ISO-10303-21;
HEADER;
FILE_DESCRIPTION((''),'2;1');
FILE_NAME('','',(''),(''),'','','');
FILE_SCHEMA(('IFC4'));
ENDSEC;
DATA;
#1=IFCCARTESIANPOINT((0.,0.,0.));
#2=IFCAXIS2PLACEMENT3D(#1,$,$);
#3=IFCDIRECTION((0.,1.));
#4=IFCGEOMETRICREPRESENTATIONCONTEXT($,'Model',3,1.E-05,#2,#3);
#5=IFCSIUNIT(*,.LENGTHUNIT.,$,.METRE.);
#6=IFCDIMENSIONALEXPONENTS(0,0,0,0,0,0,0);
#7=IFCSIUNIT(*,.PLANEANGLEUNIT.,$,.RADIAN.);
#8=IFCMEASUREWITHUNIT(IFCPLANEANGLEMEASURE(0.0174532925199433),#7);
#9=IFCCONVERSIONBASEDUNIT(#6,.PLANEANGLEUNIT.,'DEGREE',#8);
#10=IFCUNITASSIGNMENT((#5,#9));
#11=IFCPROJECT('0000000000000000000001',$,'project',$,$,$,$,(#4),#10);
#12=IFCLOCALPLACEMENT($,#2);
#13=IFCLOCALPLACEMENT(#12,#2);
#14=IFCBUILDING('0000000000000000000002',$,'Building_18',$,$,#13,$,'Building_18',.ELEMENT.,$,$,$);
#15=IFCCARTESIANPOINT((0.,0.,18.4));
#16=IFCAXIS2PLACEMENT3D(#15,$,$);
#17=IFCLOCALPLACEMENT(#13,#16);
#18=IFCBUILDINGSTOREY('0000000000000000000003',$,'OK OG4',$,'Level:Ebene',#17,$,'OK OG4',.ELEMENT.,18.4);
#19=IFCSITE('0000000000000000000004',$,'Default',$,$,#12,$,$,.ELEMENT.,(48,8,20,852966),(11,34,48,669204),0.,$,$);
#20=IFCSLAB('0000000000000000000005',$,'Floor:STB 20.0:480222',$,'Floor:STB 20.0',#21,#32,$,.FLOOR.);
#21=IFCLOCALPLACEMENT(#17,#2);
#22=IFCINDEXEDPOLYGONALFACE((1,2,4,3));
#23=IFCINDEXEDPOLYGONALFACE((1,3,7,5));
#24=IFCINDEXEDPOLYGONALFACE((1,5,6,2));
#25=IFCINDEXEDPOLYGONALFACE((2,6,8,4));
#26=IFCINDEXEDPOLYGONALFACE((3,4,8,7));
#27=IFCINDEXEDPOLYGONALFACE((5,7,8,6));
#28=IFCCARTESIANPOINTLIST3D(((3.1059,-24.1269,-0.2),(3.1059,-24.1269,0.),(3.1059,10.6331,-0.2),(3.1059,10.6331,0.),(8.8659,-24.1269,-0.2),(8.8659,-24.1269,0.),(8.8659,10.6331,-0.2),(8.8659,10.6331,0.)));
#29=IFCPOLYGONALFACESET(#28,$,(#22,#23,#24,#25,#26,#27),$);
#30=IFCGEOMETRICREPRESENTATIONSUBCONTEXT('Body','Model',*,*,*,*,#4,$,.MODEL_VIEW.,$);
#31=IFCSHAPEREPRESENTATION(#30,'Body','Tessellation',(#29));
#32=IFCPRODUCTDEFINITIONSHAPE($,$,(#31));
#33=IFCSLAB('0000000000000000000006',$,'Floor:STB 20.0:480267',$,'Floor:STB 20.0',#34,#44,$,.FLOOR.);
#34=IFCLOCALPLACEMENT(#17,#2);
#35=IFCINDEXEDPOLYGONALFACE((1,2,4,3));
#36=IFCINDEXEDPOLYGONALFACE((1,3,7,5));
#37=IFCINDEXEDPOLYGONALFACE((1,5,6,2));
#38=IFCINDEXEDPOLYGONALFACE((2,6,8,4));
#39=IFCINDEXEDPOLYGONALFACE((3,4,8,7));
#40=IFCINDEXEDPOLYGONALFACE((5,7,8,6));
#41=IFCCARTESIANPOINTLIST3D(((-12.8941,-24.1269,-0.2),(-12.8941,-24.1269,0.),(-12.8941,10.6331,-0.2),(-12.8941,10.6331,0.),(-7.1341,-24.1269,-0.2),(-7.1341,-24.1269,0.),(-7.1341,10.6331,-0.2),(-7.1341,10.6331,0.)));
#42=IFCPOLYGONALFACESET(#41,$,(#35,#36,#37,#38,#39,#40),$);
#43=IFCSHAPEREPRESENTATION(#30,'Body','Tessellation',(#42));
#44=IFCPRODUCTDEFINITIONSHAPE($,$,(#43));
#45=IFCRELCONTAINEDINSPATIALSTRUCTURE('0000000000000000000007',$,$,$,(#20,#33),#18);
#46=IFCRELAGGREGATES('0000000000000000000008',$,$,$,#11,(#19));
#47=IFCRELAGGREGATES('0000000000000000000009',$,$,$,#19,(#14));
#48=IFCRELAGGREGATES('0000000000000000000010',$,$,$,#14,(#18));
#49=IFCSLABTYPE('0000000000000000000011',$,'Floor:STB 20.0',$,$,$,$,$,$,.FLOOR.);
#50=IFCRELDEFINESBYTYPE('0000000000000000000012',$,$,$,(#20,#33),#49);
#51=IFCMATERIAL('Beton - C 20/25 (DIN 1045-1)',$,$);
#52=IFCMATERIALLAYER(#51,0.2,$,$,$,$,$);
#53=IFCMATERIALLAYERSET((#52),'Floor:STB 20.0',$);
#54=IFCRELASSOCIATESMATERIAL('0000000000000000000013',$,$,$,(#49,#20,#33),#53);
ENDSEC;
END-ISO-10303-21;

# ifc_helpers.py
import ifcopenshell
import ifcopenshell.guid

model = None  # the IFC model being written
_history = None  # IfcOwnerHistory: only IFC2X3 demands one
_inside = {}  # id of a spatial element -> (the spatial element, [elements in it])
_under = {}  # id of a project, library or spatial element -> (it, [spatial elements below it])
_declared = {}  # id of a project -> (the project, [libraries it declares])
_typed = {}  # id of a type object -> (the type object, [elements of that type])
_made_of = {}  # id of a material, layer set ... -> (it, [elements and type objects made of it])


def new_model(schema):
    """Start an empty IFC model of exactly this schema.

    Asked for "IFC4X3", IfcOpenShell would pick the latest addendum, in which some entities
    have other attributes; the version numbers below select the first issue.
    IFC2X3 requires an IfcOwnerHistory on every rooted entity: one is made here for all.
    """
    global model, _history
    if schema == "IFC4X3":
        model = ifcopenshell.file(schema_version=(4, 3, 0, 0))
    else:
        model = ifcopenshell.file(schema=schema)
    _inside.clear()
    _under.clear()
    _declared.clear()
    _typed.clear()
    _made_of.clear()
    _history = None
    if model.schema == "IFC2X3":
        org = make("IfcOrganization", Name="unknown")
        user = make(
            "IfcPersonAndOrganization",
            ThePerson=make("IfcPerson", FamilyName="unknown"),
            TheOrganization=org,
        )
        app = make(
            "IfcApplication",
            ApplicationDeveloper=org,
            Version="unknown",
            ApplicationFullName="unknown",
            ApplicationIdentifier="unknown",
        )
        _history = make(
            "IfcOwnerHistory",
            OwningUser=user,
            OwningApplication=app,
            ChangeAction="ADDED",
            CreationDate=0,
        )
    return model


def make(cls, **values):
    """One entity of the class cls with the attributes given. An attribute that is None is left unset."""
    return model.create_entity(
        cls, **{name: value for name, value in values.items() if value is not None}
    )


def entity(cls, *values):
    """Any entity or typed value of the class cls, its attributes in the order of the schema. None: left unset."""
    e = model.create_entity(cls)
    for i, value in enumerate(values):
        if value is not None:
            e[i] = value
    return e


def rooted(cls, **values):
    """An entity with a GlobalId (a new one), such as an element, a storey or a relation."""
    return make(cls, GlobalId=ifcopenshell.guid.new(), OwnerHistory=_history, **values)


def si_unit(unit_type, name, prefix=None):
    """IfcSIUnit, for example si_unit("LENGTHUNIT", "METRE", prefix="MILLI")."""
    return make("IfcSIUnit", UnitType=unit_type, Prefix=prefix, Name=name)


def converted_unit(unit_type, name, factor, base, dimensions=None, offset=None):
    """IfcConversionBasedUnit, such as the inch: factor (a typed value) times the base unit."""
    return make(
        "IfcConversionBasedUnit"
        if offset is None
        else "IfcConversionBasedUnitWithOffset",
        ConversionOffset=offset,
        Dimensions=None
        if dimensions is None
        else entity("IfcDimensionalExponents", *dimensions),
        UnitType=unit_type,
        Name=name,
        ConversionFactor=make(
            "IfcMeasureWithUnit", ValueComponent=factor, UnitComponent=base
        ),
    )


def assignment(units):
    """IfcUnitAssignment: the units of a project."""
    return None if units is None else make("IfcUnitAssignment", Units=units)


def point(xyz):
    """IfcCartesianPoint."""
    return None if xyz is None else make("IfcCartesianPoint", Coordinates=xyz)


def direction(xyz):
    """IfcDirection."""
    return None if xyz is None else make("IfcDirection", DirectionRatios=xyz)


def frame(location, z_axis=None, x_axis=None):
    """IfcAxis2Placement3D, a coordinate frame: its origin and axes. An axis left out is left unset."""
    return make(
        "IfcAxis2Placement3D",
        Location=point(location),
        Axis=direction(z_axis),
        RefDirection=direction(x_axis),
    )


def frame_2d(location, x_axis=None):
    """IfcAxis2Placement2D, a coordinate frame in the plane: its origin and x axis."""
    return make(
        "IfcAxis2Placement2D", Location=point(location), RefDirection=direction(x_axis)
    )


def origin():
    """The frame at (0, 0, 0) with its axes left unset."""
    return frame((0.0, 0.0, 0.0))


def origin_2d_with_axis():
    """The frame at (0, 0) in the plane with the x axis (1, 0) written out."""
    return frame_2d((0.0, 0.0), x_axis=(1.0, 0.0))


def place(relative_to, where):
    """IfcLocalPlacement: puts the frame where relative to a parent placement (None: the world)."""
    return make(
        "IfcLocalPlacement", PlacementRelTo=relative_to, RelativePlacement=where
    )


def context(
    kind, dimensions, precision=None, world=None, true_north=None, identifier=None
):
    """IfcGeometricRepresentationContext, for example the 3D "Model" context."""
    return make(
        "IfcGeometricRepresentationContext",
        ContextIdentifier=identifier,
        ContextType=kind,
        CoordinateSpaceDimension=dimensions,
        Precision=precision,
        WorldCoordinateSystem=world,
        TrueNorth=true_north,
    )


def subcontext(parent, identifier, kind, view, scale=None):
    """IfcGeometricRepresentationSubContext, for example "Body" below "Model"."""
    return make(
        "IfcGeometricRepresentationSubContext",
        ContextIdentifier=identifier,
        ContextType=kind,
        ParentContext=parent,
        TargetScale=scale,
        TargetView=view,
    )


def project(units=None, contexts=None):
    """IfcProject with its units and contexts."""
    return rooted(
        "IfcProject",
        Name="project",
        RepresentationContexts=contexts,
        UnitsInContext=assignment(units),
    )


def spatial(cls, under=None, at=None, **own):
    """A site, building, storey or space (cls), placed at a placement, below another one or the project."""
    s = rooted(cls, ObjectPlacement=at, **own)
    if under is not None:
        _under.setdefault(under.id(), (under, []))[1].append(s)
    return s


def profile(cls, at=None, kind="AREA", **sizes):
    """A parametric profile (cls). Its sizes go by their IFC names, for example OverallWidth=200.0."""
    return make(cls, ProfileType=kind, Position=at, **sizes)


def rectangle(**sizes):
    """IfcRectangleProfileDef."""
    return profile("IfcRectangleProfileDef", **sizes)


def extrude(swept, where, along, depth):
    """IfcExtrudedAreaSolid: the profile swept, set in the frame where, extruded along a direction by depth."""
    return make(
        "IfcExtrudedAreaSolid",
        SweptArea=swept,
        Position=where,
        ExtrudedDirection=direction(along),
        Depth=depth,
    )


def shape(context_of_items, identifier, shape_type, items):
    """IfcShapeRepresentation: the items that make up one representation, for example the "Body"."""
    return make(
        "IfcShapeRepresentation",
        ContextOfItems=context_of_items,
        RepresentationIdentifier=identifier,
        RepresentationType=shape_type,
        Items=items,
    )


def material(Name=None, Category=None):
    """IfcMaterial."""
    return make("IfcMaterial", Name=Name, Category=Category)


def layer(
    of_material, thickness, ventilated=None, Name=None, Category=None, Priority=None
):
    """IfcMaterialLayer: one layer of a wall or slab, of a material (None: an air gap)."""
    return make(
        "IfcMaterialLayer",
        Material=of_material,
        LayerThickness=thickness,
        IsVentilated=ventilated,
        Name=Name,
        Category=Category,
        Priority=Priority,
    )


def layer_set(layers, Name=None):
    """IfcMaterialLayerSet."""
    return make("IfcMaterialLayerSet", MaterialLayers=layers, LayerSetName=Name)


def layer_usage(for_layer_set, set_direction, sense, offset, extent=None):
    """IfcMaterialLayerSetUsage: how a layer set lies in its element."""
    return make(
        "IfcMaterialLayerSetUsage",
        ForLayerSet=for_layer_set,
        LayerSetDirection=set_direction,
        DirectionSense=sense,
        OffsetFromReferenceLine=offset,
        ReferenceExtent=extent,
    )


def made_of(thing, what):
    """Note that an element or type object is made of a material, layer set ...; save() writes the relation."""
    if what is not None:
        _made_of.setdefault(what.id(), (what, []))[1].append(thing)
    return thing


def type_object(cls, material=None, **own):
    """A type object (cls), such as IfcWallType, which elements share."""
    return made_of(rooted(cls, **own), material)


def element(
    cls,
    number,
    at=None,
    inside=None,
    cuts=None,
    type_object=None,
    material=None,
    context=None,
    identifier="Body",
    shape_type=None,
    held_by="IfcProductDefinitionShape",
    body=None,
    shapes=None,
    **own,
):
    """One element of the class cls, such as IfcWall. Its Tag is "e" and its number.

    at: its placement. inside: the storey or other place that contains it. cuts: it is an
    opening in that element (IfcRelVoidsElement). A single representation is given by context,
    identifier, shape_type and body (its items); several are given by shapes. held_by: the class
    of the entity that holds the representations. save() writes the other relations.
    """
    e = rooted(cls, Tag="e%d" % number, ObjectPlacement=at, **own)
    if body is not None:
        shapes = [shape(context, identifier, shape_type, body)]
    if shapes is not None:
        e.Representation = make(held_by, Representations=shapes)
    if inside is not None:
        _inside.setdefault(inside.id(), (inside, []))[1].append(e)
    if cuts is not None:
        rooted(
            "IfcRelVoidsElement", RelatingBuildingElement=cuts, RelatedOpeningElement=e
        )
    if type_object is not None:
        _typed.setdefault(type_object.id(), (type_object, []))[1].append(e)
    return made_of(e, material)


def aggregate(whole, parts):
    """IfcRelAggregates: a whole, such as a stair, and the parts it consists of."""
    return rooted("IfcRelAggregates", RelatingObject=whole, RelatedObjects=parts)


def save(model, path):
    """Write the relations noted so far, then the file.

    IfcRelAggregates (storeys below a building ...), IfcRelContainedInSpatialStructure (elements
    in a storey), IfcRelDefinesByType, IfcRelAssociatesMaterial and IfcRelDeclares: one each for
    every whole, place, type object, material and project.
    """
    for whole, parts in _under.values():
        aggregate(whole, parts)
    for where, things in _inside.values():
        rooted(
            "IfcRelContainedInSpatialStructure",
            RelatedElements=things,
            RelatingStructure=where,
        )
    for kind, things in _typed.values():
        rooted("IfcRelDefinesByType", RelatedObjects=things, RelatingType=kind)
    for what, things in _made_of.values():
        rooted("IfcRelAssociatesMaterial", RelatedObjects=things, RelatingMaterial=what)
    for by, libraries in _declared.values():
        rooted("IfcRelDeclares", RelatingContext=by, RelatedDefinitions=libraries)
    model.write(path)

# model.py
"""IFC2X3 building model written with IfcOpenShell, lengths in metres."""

from ifc_helpers import new_model, entity, si_unit, converted_unit, direction, frame, frame_2d, origin, origin_2d_with_axis, place, context, subcontext, project, spatial, rectangle, extrude, material, layer, layer_set, layer_usage, type_object, element, save


model = new_model("IFC2X3")

# Units and contexts
model_context = context("Model", 3, precision=1e-05, world=origin(), true_north=direction((0.0, 1.0)))
body_context = subcontext(model_context, "Body", "Model", "MODEL_VIEW")
ifc_project = project(units=[si_unit("LENGTHUNIT", "METRE"), converted_unit("PLANEANGLEUNIT", "DEGREE", entity("IfcPlaneAngleMeasure", 0.0174532925199433), si_unit("PLANEANGLEUNIT", "RADIAN"), dimensions=[0, 0, 0, 0, 0, 0, 0])], contexts=[model_context])

# Site, building, storey
site_placement = place(None, origin())
site = spatial("IfcSite", under=ifc_project, at=site_placement, Name="Default", CompositionType="ELEMENT", RefLatitude=(48, 8, 20, 852966), RefLongitude=(11, 34, 48, 669204), RefElevation=0.0)
building_placement = place(site_placement, origin())
building = spatial("IfcBuilding", under=site, at=building_placement, Name="Building_18", LongName="Building_18", CompositionType="ELEMENT")
storey_placement = place(building_placement, frame((0.0, 0.0, 18.4)))
storey = spatial("IfcBuildingStorey", under=building, at=storey_placement, Name="OK OG4", ObjectType="Level:Ebene", LongName="OK OG4", CompositionType="ELEMENT", Elevation=18.4)

# Slabs
ifc_material = material(Name="Beton - C 20/25 (DIN 1045-1)")
ifc_layer = layer(ifc_material, 0.2)
ifc_layer_set = layer_set([ifc_layer], Name="Floor:STB 20.0")
ifc_layer_usage_1 = layer_usage(ifc_layer_set, "AXIS3", "POSITIVE", 0.0)
slab_type = type_object("IfcSlabType", Name="Floor:STB 20.0", PredefinedType="FLOOR", material=ifc_layer_set)
slab_1_placement = place(storey_placement, origin())
element("IfcSlab", 1, at=slab_1_placement, inside=storey, type_object=slab_type, material=ifc_layer_usage_1, Name="Floor:STB 20.0:480222", ObjectType="Floor:STB 20.0", PredefinedType="FLOOR", context=body_context, shape_type="SweptSolid", body=[
    extrude(rectangle(XDim=34.76, YDim=5.76, at=origin_2d_with_axis()), frame((5.9859, -6.7469, 0.0), z_axis=(0.0, 0.0, -1.0), x_axis=(0.0, 1.0, 0.0)), (0.0, 0.0, 1.0), 0.2),
])
ifc_layer_usage_2 = layer_usage(ifc_layer_set, "AXIS3", "POSITIVE", 0.0)
slab_2_placement = place(storey_placement, origin())
element("IfcSlab", 2, at=slab_2_placement, inside=storey, type_object=slab_type, material=ifc_layer_usage_2, Name="Floor:STB 20.0:480267", ObjectType="Floor:STB 20.0", PredefinedType="FLOOR", context=body_context, shape_type="SweptSolid", body=[
    extrude(rectangle(XDim=34.76, YDim=5.76, at=frame_2d((0.0, 0.0), x_axis=(1.0, 0.0))), frame((-10.0141, -6.7469, 0.0), z_axis=(0.0, 0.0, -1.0), x_axis=(0.0, 1.0, 0.0)), (0.0, 0.0, 1.0), 0.2),
])

save(model, "model.ifc")
